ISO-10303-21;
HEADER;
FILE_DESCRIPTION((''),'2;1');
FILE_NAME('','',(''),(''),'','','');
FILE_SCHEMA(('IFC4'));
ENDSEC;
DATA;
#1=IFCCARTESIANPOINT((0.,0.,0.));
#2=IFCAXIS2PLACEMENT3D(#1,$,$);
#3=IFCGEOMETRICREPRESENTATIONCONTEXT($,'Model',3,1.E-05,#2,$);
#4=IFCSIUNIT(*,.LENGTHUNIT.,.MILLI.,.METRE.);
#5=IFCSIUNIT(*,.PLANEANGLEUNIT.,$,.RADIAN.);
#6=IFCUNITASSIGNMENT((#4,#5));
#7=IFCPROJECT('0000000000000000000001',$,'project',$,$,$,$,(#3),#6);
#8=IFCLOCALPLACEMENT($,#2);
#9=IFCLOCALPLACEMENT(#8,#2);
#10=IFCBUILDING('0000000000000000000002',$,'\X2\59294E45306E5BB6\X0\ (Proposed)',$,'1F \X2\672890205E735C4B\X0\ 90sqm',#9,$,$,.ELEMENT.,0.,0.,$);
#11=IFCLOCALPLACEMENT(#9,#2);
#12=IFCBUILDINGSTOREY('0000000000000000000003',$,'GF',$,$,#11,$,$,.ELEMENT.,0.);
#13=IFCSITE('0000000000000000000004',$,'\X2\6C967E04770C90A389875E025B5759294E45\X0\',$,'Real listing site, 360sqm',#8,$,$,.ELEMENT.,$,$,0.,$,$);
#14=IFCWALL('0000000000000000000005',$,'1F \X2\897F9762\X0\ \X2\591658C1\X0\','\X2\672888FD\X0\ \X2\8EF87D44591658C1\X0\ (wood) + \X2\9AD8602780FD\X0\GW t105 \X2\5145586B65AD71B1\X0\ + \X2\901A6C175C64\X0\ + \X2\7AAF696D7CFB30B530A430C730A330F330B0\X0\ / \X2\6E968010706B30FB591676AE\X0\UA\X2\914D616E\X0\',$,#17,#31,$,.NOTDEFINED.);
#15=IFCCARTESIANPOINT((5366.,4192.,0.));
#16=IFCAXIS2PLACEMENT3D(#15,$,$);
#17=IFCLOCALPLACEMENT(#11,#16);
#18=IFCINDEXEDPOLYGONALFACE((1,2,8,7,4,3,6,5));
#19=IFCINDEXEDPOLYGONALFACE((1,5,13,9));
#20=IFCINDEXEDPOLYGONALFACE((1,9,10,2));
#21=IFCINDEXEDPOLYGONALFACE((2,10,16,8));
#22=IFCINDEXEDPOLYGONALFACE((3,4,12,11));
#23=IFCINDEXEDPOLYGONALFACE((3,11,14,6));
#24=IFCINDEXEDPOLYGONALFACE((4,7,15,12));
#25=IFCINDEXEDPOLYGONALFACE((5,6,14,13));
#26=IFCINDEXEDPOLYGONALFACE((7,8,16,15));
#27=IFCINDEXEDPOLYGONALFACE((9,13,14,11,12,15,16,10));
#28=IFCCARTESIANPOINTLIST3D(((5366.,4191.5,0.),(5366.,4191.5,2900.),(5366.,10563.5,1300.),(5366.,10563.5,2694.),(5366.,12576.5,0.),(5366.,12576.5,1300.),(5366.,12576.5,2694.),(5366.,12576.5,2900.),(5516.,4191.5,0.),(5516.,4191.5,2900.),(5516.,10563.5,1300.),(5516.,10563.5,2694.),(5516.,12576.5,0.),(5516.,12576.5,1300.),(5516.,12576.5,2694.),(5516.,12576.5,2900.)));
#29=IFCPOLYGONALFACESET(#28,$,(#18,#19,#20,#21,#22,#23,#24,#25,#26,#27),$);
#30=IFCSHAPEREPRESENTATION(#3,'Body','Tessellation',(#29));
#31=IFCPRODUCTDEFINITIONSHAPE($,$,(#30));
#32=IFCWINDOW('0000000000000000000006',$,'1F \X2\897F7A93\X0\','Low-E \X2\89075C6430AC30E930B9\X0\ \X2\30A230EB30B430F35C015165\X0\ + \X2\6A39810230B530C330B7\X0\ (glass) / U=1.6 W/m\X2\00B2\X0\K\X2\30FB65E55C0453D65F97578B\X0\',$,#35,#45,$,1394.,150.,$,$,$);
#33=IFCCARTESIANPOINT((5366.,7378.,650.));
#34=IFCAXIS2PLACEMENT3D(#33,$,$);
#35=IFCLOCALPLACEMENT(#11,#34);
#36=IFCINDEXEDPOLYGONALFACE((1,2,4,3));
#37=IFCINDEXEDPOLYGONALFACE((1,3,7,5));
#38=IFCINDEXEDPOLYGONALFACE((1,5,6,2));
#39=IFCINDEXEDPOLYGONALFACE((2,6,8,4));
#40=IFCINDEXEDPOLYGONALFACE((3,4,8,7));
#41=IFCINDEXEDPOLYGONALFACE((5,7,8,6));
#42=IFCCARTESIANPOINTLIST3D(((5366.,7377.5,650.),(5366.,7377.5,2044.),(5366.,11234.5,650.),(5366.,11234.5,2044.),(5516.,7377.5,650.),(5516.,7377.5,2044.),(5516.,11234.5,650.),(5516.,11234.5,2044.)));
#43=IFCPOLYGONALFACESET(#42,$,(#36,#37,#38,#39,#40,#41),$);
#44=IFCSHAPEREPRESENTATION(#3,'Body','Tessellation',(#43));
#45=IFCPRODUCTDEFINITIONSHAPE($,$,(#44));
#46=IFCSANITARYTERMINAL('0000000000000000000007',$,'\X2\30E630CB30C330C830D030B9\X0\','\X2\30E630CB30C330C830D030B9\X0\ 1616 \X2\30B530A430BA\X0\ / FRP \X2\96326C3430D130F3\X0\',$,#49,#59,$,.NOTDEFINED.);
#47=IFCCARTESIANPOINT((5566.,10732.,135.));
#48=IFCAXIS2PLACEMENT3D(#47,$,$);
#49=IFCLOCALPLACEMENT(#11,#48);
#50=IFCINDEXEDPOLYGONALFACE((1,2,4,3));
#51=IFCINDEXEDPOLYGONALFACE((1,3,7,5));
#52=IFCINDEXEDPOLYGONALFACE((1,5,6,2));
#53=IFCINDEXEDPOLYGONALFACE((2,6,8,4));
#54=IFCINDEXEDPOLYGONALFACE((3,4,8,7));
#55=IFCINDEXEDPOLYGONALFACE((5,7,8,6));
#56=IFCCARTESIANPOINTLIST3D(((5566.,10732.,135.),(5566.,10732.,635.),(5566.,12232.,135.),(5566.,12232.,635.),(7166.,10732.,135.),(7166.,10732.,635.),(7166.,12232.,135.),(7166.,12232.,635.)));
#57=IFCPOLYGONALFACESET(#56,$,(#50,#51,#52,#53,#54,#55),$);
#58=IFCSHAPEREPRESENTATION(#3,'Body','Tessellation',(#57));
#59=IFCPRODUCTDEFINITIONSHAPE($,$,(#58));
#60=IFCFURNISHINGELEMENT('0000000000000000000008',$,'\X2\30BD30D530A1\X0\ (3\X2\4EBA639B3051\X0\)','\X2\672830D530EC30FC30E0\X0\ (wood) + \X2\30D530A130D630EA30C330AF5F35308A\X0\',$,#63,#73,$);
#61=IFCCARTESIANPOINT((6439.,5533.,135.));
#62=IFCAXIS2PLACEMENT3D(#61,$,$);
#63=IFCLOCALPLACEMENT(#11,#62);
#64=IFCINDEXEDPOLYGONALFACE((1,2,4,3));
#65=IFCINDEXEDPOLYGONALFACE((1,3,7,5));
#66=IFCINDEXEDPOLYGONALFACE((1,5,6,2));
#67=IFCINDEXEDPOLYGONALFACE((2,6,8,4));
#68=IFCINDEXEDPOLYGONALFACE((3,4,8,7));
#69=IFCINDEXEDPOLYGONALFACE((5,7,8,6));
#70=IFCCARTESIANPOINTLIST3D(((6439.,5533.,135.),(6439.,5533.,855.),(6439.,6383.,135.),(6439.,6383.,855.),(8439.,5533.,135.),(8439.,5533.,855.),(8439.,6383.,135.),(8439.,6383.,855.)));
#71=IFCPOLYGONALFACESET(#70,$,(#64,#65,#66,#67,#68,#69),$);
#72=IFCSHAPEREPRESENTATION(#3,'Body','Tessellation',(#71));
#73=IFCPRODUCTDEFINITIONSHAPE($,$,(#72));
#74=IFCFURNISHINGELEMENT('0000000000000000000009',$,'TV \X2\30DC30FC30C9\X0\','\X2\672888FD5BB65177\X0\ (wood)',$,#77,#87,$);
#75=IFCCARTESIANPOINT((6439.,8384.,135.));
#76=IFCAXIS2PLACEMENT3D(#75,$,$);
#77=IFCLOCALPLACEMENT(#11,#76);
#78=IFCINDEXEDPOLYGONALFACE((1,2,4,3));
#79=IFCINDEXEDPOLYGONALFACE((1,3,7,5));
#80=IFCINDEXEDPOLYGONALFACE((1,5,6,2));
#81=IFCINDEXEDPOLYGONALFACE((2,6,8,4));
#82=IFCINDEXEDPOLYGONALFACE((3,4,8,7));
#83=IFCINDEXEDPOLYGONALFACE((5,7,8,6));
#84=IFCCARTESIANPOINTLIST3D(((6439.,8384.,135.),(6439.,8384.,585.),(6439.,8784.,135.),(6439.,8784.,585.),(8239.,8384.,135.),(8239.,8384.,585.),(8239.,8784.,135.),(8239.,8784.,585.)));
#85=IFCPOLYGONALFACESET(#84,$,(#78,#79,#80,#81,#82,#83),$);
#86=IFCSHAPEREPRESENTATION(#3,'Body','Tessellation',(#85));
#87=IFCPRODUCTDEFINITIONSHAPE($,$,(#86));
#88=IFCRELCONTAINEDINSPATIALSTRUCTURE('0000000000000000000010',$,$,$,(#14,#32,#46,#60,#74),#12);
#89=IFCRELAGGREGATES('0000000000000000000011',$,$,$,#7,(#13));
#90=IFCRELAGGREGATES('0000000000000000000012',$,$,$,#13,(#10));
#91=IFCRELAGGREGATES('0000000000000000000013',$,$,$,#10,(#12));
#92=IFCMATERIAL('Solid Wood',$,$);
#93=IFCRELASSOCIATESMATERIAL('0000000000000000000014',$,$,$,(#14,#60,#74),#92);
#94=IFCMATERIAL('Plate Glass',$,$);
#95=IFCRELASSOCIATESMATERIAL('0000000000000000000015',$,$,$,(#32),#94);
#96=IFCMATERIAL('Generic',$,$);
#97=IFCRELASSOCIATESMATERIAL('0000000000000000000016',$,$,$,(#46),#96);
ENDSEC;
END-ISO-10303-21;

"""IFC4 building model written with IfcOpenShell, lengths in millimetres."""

from ifc_helpers import new_model, si_unit, frame, frame_2d, origin, place, context, project, spatial, rectangle, extrude, material, element, fill, save


model = new_model("IFC4")

# Units and contexts
model_context = context("Model", 3, precision=1e-05, world=origin())
ifc_project = project(units=[si_unit("LENGTHUNIT", "METRE", prefix="MILLI"), si_unit("PLANEANGLEUNIT", "RADIAN")], contexts=[model_context])

# Site, building, storey
site_placement = place(None, origin())
site = spatial("IfcSite", under=ifc_project, at=site_placement, Name="沖縄県那覇市字天久", ObjectType="Real listing site, 360sqm", CompositionType="ELEMENT", RefElevation=0.0)
building_placement = place(site_placement, origin())
building = spatial("IfcBuilding", under=site, at=building_placement, Name="天久の家 (Proposed)", ObjectType="1F 木造平屋 90sqm", CompositionType="ELEMENT", ElevationOfRefHeight=0.0, ElevationOfTerrain=0.0)
storey_placement = place(building_placement, origin())
storey = spatial("IfcBuildingStorey", under=building, at=storey_placement, Name="GF", CompositionType="ELEMENT", Elevation=0.0)

# Shared definitions
ifc_material_1 = material(Name="Solid Wood")

# Shared definitions
ifc_material_2 = material(Name="Plate Glass")

# Wall, opening, window
wall_1_placement = place(storey_placement, frame((5366.0, 4192.0, 0.0)))
wall_1 = element("IfcWall", 1, at=wall_1_placement, inside=storey, material=ifc_material_1, Name="1F 西面 外壁", Description="木製 軸組外壁 (wood) + 高性能GW t105 充填断熱 + 通気層 + 窯業系サイディング / 準耐火・外皮UA配慮", PredefinedType="NOTDEFINED", context=model_context, shape_type="SweptSolid", body=[
    extrude(rectangle(XDim=150.0, YDim=8385.0, at=frame_2d((75.0, 4192.0))), frame((5366.0, 4192.0, 0.0)), (0.0, 0.0, 1.0), 2900.0),
])
opening_1_placement = place(storey_placement, frame((5366.0, 7378.0, 650.0)))
opening_1 = element("IfcOpeningElement", 2, at=opening_1_placement, cuts=wall_1, PredefinedType="NOTDEFINED", context=model_context, shape_type="SweptSolid", body=[
    extrude(rectangle(XDim=150.0, YDim=3857.0, at=frame_2d((75.0, 1928.0))), frame((5366.0, 7378.0, 650.0)), (0.0, 0.0, 1.0), 1394.0),
])
window_1_placement = place(storey_placement, frame((5366.0, 7378.0, 650.0)))
window_1 = element("IfcWindow", 3, at=window_1_placement, inside=storey, material=ifc_material_2, Name="1F 西窓", Description="Low-E 複層ガラス アルゴン封入 + 樹脂サッシ (glass) / U=1.6 W/m²K・日射取得型", OverallHeight=1394.0, OverallWidth=150.0, context=model_context, shape_type="SweptSolid", body=[
    extrude(rectangle(XDim=150.0, YDim=3857.0, at=frame_2d((75.0, 1928.0))), frame((5366.0, 7378.0, 650.0)), (0.0, 0.0, 1.0), 1394.0),
])
fill(opening_1, window_1)

# Shared definitions
ifc_material_3 = material(Name="Generic")

# Sanitary terminal
sanitary_terminal_placement = place(storey_placement, frame((5566.0, 10732.0, 135.0)))
element("IfcSanitaryTerminal", 4, at=sanitary_terminal_placement, inside=storey, material=ifc_material_3, Name="ユニットバス", Description="ユニットバス 1616 サイズ / FRP 防水パン", PredefinedType="NOTDEFINED", context=model_context, shape_type="SweptSolid", body=[
    extrude(rectangle(XDim=1600.0, YDim=1500.0, at=frame_2d((800.0, 750.0))), frame((5566.0, 10732.0, 135.0)), (0.0, 0.0, 1.0), 500.0),
])

# Furnishing elements
furnishing_1_placement = place(storey_placement, frame((6439.0, 5533.0, 135.0)))
element("IfcFurnishingElement", 5, at=furnishing_1_placement, inside=storey, material=ifc_material_1, Name="ソファ (3人掛け)", Description="木フレーム (wood) + ファブリック張り", context=model_context, shape_type="SweptSolid", body=[
    extrude(rectangle(XDim=2000.0, YDim=850.0, at=frame_2d((1000.0, 425.0))), frame((6439.0, 5533.0, 135.0)), (0.0, 0.0, 1.0), 720.0),
])
furnishing_2_placement = place(storey_placement, frame((6439.0, 8384.0, 135.0)))
element("IfcFurnishingElement", 6, at=furnishing_2_placement, inside=storey, material=ifc_material_1, Name="TV ボード", Description="木製家具 (wood)", context=model_context, shape_type="SweptSolid", body=[
    extrude(rectangle(XDim=1800.0, YDim=400.0, at=frame_2d((900.0, 200.0))), frame((6439.0, 8384.0, 135.0)), (0.0, 0.0, 1.0), 450.0),
])

save(model, "model.ifc")
